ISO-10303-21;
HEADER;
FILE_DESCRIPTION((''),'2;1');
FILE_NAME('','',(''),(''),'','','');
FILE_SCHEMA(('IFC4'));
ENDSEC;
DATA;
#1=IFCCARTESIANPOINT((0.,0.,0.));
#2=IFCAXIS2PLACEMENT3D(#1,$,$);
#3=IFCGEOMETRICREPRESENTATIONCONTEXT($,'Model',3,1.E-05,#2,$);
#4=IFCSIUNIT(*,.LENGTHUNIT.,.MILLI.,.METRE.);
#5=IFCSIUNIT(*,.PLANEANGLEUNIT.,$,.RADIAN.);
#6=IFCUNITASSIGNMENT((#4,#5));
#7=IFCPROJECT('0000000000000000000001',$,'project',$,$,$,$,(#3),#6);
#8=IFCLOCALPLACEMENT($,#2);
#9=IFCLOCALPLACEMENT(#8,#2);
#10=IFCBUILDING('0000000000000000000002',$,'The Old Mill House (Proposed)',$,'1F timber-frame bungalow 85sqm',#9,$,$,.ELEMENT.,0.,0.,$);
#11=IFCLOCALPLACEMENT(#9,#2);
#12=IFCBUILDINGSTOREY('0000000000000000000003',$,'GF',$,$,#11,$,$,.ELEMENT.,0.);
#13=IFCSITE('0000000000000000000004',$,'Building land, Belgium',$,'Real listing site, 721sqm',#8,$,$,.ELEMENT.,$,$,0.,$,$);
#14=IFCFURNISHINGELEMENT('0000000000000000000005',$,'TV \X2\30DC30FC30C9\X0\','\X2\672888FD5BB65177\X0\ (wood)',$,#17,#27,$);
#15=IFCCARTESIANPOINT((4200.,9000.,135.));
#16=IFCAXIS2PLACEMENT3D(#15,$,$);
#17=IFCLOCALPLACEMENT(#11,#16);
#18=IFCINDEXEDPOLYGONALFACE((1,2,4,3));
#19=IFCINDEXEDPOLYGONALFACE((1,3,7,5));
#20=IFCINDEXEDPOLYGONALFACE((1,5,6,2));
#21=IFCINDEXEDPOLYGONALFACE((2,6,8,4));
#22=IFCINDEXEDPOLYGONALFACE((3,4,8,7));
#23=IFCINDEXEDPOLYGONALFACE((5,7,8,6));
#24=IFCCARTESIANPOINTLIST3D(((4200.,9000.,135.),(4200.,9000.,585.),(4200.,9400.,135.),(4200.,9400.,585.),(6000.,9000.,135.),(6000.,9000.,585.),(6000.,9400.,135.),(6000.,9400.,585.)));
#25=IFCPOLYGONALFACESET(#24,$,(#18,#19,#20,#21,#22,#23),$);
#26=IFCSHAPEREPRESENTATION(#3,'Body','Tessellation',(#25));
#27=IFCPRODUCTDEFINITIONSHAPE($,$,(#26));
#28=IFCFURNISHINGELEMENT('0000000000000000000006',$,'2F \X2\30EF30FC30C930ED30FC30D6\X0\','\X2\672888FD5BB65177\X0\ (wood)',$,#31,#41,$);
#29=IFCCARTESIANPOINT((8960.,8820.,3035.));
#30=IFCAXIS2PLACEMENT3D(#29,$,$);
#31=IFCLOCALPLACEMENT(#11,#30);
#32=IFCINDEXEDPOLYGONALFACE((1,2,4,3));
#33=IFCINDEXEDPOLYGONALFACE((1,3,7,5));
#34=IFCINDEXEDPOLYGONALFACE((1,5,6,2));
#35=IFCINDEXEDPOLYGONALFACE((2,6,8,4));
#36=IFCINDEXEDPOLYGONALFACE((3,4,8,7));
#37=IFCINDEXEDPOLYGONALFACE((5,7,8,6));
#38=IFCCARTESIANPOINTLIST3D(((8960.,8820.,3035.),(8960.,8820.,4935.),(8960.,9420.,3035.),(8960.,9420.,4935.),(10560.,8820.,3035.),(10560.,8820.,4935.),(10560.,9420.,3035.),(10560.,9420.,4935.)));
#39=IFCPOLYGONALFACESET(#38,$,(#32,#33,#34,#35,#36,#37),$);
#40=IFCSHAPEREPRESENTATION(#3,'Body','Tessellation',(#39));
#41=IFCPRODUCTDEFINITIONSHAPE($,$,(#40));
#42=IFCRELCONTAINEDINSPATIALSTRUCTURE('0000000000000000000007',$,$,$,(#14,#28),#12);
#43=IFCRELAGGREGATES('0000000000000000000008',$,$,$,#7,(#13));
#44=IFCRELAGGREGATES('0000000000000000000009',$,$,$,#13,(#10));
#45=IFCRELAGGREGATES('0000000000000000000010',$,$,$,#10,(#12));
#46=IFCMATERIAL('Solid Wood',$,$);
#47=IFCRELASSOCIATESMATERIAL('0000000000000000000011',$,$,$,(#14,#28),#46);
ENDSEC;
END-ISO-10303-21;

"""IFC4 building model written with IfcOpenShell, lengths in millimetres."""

from ifc_helpers import new_model, si_unit, frame, frame_2d, origin, place, context, project, spatial, rectangle, extrude, material, element, save


model = new_model("IFC4")

# Units and contexts
model_context = context("Model", 3, precision=1e-05, world=origin())
ifc_project = project(units=[si_unit("LENGTHUNIT", "METRE", prefix="MILLI"), si_unit("PLANEANGLEUNIT", "RADIAN")], contexts=[model_context])

# Site, building, storey
site_placement = place(None, origin())
site = spatial("IfcSite", under=ifc_project, at=site_placement, Name="Building land, Belgium", ObjectType="Real listing site, 721sqm", CompositionType="ELEMENT", RefElevation=0.0)
building_placement = place(site_placement, origin())
building = spatial("IfcBuilding", under=site, at=building_placement, Name="The Old Mill House (Proposed)", ObjectType="1F timber-frame bungalow 85sqm", CompositionType="ELEMENT", ElevationOfRefHeight=0.0, ElevationOfTerrain=0.0)
storey_placement = place(building_placement, origin())
storey = spatial("IfcBuildingStorey", under=building, at=storey_placement, Name="GF", CompositionType="ELEMENT", Elevation=0.0)

# Shared definitions
ifc_material_1 = material(Name="Solid Wood")

# Furnishing elements
furnishing_1_placement = place(storey_placement, frame((4200.0, 9000.0, 135.0)))
element("IfcFurnishingElement", 1, at=furnishing_1_placement, inside=storey, material=ifc_material_1, Name="TV ボード", Description="木製家具 (wood)", context=model_context, shape_type="SweptSolid", body=[
    extrude(rectangle(XDim=1800.0, YDim=400.0, at=frame_2d((900.0, 200.0))), frame((4200.0, 9000.0, 135.0)), (0.0, 0.0, 1.0), 450.0),
])
furnishing_2_placement = place(storey_placement, frame((8960.0, 8820.0, 3035.0)))
element("IfcFurnishingElement", 2, at=furnishing_2_placement, inside=storey, material=ifc_material_1, Name="2F ワードローブ", Description="木製家具 (wood)", context=model_context, shape_type="SweptSolid", body=[
    extrude(rectangle(XDim=1600.0, YDim=600.0, at=frame_2d((800.0, 300.0))), frame((8960.0, 8820.0, 3035.0)), (0.0, 0.0, 1.0), 1900.0),
])

save(model, "model.ifc")
